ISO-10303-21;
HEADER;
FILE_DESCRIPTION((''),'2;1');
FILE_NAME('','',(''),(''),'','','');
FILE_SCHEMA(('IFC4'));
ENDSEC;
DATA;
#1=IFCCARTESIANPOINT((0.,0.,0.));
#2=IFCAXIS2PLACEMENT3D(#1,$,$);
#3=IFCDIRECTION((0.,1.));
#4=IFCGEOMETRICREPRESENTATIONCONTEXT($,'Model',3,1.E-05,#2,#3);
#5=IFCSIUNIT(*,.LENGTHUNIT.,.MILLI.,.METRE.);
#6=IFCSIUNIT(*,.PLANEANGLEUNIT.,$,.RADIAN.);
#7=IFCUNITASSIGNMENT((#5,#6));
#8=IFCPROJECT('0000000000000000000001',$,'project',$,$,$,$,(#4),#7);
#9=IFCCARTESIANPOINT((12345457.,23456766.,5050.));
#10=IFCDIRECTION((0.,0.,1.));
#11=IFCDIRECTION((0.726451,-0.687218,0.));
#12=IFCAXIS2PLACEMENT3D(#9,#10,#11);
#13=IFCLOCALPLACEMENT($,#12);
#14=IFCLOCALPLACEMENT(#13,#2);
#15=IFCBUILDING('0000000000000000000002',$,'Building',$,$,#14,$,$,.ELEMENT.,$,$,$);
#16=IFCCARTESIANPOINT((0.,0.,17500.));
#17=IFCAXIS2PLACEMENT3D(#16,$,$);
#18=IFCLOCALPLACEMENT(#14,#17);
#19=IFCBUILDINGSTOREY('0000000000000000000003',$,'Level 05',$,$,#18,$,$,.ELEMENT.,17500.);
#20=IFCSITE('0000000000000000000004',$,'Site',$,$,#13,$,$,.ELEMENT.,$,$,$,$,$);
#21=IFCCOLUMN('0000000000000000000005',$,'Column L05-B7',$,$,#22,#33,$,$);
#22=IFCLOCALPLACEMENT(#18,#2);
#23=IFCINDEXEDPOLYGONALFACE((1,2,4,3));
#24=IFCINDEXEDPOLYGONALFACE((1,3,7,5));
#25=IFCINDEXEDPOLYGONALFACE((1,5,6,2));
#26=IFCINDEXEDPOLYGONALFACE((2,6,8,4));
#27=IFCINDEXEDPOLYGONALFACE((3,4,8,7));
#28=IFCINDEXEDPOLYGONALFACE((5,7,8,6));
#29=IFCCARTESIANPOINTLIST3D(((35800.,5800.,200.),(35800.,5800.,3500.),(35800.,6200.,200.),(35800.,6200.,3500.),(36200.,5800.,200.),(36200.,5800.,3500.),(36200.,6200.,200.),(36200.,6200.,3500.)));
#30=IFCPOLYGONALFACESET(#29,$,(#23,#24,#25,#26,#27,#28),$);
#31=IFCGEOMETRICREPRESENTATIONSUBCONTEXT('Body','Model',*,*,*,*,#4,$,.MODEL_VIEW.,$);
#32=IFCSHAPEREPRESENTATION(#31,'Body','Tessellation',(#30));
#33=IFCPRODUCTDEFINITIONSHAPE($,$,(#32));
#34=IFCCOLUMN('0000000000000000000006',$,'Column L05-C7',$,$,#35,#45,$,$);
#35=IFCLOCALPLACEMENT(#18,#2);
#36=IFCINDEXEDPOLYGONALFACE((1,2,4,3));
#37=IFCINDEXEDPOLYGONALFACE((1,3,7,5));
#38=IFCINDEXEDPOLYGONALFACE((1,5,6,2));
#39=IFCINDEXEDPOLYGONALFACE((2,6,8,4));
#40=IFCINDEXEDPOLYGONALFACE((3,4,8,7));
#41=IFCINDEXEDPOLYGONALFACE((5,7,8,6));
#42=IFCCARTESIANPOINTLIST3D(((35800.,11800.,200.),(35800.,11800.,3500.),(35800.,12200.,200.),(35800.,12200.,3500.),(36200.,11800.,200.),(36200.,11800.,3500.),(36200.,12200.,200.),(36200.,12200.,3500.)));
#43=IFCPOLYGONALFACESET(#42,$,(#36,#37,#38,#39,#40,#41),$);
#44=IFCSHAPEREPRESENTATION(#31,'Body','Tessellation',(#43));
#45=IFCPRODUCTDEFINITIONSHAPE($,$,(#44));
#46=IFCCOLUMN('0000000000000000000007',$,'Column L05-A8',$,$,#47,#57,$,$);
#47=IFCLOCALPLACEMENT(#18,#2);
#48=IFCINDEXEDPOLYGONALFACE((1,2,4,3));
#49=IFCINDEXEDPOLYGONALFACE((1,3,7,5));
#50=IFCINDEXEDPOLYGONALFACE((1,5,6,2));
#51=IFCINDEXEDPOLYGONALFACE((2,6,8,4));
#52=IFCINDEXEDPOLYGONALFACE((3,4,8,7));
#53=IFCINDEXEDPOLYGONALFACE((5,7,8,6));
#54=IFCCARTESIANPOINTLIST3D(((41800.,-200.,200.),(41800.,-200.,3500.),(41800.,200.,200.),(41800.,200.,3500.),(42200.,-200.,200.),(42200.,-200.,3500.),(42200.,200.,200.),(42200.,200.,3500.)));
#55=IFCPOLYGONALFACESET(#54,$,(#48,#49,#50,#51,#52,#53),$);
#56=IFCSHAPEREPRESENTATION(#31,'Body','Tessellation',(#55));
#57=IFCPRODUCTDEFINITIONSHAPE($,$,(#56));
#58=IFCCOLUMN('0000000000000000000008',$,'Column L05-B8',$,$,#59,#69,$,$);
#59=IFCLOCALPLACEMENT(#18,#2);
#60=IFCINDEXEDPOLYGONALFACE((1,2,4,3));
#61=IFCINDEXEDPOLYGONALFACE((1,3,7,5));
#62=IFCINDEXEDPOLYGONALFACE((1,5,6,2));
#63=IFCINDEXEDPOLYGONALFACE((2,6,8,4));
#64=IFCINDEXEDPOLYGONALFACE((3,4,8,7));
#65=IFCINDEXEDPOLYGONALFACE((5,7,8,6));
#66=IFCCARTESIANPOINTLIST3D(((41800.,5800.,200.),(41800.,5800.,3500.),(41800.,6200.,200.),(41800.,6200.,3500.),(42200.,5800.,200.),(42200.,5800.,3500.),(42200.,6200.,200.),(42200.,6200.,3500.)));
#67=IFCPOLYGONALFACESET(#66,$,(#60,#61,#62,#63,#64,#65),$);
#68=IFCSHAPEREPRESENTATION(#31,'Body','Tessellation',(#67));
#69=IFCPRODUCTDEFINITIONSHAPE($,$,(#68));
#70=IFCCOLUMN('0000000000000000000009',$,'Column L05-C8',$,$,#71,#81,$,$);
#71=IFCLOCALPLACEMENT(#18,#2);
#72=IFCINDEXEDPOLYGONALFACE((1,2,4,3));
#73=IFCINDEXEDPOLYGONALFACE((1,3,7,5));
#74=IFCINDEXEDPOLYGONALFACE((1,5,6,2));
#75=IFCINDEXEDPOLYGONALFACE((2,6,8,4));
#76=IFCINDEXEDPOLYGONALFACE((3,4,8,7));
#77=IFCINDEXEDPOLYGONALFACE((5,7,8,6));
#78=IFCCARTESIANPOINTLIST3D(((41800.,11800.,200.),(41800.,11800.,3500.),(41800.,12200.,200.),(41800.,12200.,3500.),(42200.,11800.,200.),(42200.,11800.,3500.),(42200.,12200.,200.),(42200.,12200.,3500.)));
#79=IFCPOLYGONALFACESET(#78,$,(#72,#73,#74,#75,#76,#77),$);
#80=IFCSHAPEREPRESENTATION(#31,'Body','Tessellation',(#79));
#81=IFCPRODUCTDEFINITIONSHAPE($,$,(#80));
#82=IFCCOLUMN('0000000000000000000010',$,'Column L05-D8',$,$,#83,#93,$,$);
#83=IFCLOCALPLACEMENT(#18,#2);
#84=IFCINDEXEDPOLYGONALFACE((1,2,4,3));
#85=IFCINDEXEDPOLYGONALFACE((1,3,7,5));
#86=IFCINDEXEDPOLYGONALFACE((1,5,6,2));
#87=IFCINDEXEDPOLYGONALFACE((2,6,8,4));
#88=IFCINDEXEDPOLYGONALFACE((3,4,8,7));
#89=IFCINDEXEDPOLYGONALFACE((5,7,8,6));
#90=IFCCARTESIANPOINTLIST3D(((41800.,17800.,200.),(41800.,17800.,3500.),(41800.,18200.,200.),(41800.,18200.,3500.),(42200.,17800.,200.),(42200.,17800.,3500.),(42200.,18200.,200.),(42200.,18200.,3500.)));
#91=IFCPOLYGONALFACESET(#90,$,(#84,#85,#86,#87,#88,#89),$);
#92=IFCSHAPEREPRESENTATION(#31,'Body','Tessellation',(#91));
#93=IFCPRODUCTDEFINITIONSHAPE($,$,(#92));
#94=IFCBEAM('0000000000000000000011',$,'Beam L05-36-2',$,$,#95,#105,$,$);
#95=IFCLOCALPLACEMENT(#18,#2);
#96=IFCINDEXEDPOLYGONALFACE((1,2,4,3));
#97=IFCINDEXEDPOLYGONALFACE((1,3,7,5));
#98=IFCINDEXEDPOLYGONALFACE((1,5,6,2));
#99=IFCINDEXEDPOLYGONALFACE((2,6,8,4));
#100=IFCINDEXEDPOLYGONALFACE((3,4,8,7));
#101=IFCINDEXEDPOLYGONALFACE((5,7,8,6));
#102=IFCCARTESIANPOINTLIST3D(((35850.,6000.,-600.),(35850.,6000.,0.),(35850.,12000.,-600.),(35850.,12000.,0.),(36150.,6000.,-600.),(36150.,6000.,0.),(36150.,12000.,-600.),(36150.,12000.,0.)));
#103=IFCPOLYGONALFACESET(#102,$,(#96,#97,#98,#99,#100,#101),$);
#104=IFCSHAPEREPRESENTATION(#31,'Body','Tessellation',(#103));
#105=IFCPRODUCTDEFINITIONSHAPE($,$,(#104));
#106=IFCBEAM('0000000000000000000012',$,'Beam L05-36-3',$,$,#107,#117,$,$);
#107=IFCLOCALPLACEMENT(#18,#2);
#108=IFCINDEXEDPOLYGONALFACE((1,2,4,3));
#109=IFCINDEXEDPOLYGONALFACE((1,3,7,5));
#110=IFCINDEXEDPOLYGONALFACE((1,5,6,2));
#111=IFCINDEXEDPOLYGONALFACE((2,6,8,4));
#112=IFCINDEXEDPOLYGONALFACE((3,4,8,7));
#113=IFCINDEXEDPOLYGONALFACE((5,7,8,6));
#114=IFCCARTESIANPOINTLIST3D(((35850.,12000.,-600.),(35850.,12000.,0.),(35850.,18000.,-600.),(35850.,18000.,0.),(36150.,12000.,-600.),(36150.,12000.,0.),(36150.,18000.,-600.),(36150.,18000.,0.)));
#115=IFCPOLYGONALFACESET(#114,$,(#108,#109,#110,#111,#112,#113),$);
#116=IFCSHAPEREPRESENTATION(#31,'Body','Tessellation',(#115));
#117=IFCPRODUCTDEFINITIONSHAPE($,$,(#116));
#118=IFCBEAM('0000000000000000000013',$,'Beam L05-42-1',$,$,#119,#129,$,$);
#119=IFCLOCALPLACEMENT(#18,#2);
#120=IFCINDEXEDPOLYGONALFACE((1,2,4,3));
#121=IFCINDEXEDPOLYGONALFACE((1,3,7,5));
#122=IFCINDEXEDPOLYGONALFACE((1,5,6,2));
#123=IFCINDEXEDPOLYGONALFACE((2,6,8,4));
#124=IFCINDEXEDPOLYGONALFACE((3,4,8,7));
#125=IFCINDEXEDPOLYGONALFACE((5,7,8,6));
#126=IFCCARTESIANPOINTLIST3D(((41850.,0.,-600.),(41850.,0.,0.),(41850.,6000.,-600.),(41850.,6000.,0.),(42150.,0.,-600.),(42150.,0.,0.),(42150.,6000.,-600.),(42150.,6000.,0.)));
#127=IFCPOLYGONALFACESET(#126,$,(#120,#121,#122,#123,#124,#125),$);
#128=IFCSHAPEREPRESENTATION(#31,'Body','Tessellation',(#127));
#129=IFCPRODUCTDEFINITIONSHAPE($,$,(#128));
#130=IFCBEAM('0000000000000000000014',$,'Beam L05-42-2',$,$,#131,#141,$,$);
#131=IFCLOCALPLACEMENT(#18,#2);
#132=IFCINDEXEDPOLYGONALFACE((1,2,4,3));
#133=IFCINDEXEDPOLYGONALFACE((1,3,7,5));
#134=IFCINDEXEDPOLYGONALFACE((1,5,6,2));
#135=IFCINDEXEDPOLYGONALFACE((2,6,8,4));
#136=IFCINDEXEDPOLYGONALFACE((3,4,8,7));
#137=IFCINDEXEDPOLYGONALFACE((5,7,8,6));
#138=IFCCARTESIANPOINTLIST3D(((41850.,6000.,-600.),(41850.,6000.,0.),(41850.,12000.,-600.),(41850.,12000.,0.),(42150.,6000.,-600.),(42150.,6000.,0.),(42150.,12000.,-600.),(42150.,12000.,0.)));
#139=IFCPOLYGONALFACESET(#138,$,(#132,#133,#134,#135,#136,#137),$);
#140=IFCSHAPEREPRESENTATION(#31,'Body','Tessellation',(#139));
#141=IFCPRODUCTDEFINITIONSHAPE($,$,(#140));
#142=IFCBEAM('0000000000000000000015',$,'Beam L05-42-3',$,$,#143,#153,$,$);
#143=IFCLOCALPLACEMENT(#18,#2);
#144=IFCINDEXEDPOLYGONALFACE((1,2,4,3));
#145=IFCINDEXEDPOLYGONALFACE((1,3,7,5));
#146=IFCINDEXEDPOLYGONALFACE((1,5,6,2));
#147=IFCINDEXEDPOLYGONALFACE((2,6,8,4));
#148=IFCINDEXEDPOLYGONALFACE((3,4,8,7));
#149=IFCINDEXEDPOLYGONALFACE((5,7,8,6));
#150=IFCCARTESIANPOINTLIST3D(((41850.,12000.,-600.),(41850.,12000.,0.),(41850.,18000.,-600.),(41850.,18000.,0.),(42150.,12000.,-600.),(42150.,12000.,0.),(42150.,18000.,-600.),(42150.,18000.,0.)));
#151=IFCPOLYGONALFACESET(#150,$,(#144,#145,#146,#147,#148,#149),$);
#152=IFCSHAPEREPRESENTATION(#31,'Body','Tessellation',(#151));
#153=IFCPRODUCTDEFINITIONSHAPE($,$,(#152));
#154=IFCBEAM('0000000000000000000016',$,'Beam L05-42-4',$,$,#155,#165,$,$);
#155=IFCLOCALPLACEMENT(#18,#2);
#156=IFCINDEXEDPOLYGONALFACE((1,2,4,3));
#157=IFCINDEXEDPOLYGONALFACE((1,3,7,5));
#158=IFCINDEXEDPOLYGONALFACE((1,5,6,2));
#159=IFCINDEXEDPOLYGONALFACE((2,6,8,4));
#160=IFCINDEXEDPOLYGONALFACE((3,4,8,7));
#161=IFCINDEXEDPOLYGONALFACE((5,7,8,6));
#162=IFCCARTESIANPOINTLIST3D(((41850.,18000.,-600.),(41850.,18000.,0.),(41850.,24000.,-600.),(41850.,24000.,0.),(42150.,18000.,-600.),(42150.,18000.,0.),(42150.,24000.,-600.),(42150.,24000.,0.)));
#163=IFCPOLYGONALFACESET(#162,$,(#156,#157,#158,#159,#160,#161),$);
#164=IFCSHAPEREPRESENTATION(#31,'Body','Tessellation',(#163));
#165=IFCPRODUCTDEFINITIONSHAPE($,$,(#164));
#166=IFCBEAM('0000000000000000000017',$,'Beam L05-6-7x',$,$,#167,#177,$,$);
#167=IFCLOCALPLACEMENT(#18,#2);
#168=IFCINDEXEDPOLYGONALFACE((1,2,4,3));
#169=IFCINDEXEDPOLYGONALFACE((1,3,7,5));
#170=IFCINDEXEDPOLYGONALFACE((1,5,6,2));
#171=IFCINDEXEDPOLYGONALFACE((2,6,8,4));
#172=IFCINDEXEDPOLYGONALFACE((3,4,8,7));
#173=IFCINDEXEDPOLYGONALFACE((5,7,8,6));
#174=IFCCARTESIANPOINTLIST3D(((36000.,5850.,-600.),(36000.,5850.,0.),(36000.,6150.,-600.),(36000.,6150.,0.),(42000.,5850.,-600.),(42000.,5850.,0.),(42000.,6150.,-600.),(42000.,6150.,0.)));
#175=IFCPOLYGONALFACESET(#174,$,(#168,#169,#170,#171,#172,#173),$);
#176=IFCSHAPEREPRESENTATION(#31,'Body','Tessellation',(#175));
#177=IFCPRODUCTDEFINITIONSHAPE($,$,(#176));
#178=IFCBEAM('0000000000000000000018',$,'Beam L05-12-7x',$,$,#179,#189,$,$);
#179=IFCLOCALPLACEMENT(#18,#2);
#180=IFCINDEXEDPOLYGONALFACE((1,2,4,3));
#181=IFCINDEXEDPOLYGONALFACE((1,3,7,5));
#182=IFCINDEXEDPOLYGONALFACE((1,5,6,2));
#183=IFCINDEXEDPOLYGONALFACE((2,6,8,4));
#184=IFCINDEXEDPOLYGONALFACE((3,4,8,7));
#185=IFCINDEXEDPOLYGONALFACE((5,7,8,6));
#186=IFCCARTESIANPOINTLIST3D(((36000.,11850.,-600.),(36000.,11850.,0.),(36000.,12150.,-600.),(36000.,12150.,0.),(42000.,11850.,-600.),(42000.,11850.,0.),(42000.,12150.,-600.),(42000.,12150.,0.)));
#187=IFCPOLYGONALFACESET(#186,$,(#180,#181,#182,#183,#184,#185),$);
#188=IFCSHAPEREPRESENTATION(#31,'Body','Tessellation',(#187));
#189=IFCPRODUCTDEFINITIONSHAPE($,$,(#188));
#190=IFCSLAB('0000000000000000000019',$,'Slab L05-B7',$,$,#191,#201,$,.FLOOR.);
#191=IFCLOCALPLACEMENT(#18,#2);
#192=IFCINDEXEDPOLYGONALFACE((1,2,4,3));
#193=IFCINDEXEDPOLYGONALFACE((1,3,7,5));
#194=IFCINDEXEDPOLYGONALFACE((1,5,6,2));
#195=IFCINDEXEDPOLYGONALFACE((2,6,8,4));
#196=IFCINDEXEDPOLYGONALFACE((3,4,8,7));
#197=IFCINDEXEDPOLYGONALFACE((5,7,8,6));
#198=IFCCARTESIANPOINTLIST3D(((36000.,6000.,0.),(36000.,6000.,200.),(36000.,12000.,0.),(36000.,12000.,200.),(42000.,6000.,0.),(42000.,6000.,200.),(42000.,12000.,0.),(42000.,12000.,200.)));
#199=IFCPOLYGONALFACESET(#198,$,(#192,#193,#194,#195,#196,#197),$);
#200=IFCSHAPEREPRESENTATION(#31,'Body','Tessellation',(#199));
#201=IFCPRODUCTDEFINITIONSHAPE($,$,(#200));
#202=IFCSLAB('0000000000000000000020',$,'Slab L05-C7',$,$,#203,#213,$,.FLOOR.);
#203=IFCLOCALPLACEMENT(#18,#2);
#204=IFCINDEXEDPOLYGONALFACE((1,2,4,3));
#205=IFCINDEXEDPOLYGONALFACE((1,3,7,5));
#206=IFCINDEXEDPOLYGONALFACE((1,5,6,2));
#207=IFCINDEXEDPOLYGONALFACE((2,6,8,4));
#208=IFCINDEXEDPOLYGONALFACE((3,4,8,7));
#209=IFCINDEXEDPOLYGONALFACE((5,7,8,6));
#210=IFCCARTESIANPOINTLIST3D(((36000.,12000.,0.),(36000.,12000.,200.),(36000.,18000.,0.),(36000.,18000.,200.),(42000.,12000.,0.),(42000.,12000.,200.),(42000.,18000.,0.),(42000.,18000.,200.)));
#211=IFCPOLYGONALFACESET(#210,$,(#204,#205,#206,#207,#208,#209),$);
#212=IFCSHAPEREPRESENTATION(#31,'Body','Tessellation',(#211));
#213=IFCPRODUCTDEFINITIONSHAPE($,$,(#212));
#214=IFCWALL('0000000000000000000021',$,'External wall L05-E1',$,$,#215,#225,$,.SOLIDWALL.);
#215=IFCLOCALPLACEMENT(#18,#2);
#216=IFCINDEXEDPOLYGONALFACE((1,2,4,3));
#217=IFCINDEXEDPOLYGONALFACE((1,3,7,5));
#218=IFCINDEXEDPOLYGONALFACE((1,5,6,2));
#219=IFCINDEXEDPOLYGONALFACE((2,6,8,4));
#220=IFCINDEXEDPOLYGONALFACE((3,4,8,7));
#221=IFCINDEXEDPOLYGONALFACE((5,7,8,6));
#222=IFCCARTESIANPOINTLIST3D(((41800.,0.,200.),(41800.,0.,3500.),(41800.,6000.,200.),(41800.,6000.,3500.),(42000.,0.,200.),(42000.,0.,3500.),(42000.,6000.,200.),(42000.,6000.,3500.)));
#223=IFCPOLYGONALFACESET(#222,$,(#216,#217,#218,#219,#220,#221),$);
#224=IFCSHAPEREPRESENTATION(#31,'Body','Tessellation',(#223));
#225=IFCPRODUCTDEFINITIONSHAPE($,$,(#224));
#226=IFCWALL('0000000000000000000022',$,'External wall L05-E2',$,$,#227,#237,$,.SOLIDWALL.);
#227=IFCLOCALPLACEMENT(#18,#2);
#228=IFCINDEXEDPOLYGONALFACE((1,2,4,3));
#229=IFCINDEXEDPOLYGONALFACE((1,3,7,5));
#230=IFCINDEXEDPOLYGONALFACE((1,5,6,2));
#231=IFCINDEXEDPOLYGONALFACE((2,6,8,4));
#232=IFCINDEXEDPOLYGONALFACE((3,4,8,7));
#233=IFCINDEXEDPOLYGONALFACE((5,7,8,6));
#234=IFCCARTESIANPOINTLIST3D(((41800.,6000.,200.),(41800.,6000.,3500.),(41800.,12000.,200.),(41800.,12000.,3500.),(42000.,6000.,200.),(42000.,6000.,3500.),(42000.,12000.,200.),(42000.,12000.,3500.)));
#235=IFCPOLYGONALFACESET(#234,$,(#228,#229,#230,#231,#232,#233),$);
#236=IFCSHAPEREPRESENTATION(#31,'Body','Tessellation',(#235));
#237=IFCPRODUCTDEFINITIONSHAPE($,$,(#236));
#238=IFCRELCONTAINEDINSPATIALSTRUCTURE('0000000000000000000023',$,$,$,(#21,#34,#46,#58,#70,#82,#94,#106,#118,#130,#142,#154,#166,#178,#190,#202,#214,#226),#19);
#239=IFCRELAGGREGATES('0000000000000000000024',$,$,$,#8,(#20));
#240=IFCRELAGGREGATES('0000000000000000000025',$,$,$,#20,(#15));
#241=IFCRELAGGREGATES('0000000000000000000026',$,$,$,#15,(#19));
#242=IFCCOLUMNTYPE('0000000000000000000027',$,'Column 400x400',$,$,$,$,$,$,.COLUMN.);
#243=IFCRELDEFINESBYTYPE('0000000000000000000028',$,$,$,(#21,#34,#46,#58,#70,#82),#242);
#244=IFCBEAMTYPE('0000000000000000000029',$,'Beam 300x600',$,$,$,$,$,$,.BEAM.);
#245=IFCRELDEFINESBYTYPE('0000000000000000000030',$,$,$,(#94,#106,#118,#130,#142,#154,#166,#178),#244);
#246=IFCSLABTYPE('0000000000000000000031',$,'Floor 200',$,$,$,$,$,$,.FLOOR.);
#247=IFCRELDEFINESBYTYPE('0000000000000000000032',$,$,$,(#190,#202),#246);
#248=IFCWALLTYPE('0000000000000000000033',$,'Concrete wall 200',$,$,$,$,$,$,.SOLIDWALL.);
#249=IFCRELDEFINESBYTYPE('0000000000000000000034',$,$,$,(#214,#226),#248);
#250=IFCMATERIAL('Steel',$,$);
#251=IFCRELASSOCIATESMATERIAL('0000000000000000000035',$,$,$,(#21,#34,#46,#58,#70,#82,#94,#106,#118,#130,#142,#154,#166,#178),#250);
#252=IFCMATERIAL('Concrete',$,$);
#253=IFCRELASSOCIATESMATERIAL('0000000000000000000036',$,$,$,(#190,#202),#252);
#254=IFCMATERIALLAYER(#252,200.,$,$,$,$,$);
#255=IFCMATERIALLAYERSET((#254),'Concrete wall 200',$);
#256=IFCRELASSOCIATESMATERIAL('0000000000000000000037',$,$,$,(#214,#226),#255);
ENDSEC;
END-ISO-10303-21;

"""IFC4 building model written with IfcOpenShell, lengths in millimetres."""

from ifc_helpers import new_model, si_unit, direction, frame, origin, place, context, subcontext, project, spatial, rectangle, extrude, material, layer, layer_set, layer_usage, type_object, element, save


model = new_model("IFC4")

# Units and contexts
model_context = context("Model", 3, precision=1e-05, world=origin(), true_north=direction((0.0, 1.0)))
body_context = subcontext(model_context, "Body", "Model", "MODEL_VIEW")
ifc_project = project(units=[si_unit("LENGTHUNIT", "METRE", prefix="MILLI"), si_unit("PLANEANGLEUNIT", "RADIAN")], contexts=[model_context])

# Site, building, storey
site_placement = place(None, frame((12345457.0, 23456766.0, 5050.0), z_axis=(0.0, 0.0, 1.0), x_axis=(0.726451, -0.687218, 0.0)))
site = spatial("IfcSite", under=ifc_project, at=site_placement, Name="Site", CompositionType="ELEMENT")
building_placement = place(site_placement, origin())
building = spatial("IfcBuilding", under=site, at=building_placement, Name="Building", CompositionType="ELEMENT")
storey_placement = place(building_placement, frame((0.0, 0.0, 17500.0)))
storey = spatial("IfcBuildingStorey", under=building, at=storey_placement, Name="Level 05", CompositionType="ELEMENT", Elevation=17500.0)

# Columns
ifc_material_1 = material(Name="Steel")
column_type = type_object("IfcColumnType", Name="Column 400x400", PredefinedType="COLUMN")
for number, where, name in (
    (1, (35800.0, 5800.0, 200.0), "Column L05-B7"),
    (2, (35800.0, 11800.0, 200.0), "Column L05-C7"),
    (3, (41800.0, -200.0, 200.0), "Column L05-A8"),
    (4, (41800.0, 5800.0, 200.0), "Column L05-B8"),
    (5, (41800.0, 11800.0, 200.0), "Column L05-C8"),
    (6, (41800.0, 17800.0, 200.0), "Column L05-D8"),
):
    element("IfcColumn", number, at=place(storey_placement, frame(where)), inside=storey, type_object=column_type, material=ifc_material_1, Name=name, context=body_context, shape_type="SweptSolid", body=[
        extrude(rectangle(XDim=400.0, YDim=400.0), frame((200.0, 200.0, 0.0)), (0.0, 0.0, 1.0), 3300.0),
    ])

# Beams
beam_type = type_object("IfcBeamType", Name="Beam 300x600", PredefinedType="BEAM")
for number, where, name in (
    (7, (35850.0, 6000.0, -600.0), "Beam L05-36-2"),
    (8, (35850.0, 12000.0, -600.0), "Beam L05-36-3"),
    (9, (41850.0, 0.0, -600.0), "Beam L05-42-1"),
    (10, (41850.0, 6000.0, -600.0), "Beam L05-42-2"),
    (11, (41850.0, 12000.0, -600.0), "Beam L05-42-3"),
    (12, (41850.0, 18000.0, -600.0), "Beam L05-42-4"),
):
    element("IfcBeam", number, at=place(storey_placement, frame(where)), inside=storey, type_object=beam_type, material=ifc_material_1, Name=name, context=body_context, shape_type="SweptSolid", body=[
        extrude(rectangle(XDim=300.0, YDim=6000.0), frame((150.0, 3000.0, 0.0)), (0.0, 0.0, 1.0), 600.0),
    ])
for number, where, name in (
    (13, (36000.0, 5850.0, -600.0), "Beam L05-6-7x"),
    (14, (36000.0, 11850.0, -600.0), "Beam L05-12-7x"),
):
    element("IfcBeam", number, at=place(storey_placement, frame(where)), inside=storey, type_object=beam_type, material=ifc_material_1, Name=name, context=body_context, shape_type="SweptSolid", body=[
        extrude(rectangle(XDim=6000.0, YDim=300.0), frame((3000.0, 150.0, 0.0)), (0.0, 0.0, 1.0), 600.0),
    ])

# Slabs
ifc_material_2 = material(Name="Concrete")
slab_type = type_object("IfcSlabType", Name="Floor 200", PredefinedType="FLOOR")
for number, where, name in (
    (15, (36000.0, 6000.0, 0.0), "Slab L05-B7"),
    (16, (36000.0, 12000.0, 0.0), "Slab L05-C7"),
):
    element("IfcSlab", number, at=place(storey_placement, frame(where)), inside=storey, type_object=slab_type, material=ifc_material_2, Name=name, PredefinedType="FLOOR", context=body_context, shape_type="SweptSolid", body=[
        extrude(rectangle(XDim=6000.0, YDim=6000.0), frame((3000.0, 3000.0, 0.0)), (0.0, 0.0, 1.0), 200.0),
    ])

# Walls
ifc_layer_1 = layer(ifc_material_2, 200.0)
ifc_layer_set_1 = layer_set([ifc_layer_1], Name="Concrete wall 200")
ifc_layer_usage_1 = layer_usage(ifc_layer_set_1, "AXIS2", "POSITIVE", 0.0)
wall_type_1 = type_object("IfcWallType", Name="Concrete wall 200", PredefinedType="SOLIDWALL")
for number, where, name in (
    (17, (41800.0, 0.0, 200.0), "External wall L05-E1"),
    (18, (41800.0, 6000.0, 200.0), "External wall L05-E2"),
):
    element("IfcWall", number, at=place(storey_placement, frame(where)), inside=storey, type_object=wall_type_1, material=ifc_layer_usage_1, Name=name, PredefinedType="SOLIDWALL", context=body_context, shape_type="SweptSolid", body=[
        extrude(rectangle(XDim=200.0, YDim=6000.0), frame((100.0, 3000.0, 0.0)), (0.0, 0.0, 1.0), 3300.0),
    ])

save(model, "model.ifc")
